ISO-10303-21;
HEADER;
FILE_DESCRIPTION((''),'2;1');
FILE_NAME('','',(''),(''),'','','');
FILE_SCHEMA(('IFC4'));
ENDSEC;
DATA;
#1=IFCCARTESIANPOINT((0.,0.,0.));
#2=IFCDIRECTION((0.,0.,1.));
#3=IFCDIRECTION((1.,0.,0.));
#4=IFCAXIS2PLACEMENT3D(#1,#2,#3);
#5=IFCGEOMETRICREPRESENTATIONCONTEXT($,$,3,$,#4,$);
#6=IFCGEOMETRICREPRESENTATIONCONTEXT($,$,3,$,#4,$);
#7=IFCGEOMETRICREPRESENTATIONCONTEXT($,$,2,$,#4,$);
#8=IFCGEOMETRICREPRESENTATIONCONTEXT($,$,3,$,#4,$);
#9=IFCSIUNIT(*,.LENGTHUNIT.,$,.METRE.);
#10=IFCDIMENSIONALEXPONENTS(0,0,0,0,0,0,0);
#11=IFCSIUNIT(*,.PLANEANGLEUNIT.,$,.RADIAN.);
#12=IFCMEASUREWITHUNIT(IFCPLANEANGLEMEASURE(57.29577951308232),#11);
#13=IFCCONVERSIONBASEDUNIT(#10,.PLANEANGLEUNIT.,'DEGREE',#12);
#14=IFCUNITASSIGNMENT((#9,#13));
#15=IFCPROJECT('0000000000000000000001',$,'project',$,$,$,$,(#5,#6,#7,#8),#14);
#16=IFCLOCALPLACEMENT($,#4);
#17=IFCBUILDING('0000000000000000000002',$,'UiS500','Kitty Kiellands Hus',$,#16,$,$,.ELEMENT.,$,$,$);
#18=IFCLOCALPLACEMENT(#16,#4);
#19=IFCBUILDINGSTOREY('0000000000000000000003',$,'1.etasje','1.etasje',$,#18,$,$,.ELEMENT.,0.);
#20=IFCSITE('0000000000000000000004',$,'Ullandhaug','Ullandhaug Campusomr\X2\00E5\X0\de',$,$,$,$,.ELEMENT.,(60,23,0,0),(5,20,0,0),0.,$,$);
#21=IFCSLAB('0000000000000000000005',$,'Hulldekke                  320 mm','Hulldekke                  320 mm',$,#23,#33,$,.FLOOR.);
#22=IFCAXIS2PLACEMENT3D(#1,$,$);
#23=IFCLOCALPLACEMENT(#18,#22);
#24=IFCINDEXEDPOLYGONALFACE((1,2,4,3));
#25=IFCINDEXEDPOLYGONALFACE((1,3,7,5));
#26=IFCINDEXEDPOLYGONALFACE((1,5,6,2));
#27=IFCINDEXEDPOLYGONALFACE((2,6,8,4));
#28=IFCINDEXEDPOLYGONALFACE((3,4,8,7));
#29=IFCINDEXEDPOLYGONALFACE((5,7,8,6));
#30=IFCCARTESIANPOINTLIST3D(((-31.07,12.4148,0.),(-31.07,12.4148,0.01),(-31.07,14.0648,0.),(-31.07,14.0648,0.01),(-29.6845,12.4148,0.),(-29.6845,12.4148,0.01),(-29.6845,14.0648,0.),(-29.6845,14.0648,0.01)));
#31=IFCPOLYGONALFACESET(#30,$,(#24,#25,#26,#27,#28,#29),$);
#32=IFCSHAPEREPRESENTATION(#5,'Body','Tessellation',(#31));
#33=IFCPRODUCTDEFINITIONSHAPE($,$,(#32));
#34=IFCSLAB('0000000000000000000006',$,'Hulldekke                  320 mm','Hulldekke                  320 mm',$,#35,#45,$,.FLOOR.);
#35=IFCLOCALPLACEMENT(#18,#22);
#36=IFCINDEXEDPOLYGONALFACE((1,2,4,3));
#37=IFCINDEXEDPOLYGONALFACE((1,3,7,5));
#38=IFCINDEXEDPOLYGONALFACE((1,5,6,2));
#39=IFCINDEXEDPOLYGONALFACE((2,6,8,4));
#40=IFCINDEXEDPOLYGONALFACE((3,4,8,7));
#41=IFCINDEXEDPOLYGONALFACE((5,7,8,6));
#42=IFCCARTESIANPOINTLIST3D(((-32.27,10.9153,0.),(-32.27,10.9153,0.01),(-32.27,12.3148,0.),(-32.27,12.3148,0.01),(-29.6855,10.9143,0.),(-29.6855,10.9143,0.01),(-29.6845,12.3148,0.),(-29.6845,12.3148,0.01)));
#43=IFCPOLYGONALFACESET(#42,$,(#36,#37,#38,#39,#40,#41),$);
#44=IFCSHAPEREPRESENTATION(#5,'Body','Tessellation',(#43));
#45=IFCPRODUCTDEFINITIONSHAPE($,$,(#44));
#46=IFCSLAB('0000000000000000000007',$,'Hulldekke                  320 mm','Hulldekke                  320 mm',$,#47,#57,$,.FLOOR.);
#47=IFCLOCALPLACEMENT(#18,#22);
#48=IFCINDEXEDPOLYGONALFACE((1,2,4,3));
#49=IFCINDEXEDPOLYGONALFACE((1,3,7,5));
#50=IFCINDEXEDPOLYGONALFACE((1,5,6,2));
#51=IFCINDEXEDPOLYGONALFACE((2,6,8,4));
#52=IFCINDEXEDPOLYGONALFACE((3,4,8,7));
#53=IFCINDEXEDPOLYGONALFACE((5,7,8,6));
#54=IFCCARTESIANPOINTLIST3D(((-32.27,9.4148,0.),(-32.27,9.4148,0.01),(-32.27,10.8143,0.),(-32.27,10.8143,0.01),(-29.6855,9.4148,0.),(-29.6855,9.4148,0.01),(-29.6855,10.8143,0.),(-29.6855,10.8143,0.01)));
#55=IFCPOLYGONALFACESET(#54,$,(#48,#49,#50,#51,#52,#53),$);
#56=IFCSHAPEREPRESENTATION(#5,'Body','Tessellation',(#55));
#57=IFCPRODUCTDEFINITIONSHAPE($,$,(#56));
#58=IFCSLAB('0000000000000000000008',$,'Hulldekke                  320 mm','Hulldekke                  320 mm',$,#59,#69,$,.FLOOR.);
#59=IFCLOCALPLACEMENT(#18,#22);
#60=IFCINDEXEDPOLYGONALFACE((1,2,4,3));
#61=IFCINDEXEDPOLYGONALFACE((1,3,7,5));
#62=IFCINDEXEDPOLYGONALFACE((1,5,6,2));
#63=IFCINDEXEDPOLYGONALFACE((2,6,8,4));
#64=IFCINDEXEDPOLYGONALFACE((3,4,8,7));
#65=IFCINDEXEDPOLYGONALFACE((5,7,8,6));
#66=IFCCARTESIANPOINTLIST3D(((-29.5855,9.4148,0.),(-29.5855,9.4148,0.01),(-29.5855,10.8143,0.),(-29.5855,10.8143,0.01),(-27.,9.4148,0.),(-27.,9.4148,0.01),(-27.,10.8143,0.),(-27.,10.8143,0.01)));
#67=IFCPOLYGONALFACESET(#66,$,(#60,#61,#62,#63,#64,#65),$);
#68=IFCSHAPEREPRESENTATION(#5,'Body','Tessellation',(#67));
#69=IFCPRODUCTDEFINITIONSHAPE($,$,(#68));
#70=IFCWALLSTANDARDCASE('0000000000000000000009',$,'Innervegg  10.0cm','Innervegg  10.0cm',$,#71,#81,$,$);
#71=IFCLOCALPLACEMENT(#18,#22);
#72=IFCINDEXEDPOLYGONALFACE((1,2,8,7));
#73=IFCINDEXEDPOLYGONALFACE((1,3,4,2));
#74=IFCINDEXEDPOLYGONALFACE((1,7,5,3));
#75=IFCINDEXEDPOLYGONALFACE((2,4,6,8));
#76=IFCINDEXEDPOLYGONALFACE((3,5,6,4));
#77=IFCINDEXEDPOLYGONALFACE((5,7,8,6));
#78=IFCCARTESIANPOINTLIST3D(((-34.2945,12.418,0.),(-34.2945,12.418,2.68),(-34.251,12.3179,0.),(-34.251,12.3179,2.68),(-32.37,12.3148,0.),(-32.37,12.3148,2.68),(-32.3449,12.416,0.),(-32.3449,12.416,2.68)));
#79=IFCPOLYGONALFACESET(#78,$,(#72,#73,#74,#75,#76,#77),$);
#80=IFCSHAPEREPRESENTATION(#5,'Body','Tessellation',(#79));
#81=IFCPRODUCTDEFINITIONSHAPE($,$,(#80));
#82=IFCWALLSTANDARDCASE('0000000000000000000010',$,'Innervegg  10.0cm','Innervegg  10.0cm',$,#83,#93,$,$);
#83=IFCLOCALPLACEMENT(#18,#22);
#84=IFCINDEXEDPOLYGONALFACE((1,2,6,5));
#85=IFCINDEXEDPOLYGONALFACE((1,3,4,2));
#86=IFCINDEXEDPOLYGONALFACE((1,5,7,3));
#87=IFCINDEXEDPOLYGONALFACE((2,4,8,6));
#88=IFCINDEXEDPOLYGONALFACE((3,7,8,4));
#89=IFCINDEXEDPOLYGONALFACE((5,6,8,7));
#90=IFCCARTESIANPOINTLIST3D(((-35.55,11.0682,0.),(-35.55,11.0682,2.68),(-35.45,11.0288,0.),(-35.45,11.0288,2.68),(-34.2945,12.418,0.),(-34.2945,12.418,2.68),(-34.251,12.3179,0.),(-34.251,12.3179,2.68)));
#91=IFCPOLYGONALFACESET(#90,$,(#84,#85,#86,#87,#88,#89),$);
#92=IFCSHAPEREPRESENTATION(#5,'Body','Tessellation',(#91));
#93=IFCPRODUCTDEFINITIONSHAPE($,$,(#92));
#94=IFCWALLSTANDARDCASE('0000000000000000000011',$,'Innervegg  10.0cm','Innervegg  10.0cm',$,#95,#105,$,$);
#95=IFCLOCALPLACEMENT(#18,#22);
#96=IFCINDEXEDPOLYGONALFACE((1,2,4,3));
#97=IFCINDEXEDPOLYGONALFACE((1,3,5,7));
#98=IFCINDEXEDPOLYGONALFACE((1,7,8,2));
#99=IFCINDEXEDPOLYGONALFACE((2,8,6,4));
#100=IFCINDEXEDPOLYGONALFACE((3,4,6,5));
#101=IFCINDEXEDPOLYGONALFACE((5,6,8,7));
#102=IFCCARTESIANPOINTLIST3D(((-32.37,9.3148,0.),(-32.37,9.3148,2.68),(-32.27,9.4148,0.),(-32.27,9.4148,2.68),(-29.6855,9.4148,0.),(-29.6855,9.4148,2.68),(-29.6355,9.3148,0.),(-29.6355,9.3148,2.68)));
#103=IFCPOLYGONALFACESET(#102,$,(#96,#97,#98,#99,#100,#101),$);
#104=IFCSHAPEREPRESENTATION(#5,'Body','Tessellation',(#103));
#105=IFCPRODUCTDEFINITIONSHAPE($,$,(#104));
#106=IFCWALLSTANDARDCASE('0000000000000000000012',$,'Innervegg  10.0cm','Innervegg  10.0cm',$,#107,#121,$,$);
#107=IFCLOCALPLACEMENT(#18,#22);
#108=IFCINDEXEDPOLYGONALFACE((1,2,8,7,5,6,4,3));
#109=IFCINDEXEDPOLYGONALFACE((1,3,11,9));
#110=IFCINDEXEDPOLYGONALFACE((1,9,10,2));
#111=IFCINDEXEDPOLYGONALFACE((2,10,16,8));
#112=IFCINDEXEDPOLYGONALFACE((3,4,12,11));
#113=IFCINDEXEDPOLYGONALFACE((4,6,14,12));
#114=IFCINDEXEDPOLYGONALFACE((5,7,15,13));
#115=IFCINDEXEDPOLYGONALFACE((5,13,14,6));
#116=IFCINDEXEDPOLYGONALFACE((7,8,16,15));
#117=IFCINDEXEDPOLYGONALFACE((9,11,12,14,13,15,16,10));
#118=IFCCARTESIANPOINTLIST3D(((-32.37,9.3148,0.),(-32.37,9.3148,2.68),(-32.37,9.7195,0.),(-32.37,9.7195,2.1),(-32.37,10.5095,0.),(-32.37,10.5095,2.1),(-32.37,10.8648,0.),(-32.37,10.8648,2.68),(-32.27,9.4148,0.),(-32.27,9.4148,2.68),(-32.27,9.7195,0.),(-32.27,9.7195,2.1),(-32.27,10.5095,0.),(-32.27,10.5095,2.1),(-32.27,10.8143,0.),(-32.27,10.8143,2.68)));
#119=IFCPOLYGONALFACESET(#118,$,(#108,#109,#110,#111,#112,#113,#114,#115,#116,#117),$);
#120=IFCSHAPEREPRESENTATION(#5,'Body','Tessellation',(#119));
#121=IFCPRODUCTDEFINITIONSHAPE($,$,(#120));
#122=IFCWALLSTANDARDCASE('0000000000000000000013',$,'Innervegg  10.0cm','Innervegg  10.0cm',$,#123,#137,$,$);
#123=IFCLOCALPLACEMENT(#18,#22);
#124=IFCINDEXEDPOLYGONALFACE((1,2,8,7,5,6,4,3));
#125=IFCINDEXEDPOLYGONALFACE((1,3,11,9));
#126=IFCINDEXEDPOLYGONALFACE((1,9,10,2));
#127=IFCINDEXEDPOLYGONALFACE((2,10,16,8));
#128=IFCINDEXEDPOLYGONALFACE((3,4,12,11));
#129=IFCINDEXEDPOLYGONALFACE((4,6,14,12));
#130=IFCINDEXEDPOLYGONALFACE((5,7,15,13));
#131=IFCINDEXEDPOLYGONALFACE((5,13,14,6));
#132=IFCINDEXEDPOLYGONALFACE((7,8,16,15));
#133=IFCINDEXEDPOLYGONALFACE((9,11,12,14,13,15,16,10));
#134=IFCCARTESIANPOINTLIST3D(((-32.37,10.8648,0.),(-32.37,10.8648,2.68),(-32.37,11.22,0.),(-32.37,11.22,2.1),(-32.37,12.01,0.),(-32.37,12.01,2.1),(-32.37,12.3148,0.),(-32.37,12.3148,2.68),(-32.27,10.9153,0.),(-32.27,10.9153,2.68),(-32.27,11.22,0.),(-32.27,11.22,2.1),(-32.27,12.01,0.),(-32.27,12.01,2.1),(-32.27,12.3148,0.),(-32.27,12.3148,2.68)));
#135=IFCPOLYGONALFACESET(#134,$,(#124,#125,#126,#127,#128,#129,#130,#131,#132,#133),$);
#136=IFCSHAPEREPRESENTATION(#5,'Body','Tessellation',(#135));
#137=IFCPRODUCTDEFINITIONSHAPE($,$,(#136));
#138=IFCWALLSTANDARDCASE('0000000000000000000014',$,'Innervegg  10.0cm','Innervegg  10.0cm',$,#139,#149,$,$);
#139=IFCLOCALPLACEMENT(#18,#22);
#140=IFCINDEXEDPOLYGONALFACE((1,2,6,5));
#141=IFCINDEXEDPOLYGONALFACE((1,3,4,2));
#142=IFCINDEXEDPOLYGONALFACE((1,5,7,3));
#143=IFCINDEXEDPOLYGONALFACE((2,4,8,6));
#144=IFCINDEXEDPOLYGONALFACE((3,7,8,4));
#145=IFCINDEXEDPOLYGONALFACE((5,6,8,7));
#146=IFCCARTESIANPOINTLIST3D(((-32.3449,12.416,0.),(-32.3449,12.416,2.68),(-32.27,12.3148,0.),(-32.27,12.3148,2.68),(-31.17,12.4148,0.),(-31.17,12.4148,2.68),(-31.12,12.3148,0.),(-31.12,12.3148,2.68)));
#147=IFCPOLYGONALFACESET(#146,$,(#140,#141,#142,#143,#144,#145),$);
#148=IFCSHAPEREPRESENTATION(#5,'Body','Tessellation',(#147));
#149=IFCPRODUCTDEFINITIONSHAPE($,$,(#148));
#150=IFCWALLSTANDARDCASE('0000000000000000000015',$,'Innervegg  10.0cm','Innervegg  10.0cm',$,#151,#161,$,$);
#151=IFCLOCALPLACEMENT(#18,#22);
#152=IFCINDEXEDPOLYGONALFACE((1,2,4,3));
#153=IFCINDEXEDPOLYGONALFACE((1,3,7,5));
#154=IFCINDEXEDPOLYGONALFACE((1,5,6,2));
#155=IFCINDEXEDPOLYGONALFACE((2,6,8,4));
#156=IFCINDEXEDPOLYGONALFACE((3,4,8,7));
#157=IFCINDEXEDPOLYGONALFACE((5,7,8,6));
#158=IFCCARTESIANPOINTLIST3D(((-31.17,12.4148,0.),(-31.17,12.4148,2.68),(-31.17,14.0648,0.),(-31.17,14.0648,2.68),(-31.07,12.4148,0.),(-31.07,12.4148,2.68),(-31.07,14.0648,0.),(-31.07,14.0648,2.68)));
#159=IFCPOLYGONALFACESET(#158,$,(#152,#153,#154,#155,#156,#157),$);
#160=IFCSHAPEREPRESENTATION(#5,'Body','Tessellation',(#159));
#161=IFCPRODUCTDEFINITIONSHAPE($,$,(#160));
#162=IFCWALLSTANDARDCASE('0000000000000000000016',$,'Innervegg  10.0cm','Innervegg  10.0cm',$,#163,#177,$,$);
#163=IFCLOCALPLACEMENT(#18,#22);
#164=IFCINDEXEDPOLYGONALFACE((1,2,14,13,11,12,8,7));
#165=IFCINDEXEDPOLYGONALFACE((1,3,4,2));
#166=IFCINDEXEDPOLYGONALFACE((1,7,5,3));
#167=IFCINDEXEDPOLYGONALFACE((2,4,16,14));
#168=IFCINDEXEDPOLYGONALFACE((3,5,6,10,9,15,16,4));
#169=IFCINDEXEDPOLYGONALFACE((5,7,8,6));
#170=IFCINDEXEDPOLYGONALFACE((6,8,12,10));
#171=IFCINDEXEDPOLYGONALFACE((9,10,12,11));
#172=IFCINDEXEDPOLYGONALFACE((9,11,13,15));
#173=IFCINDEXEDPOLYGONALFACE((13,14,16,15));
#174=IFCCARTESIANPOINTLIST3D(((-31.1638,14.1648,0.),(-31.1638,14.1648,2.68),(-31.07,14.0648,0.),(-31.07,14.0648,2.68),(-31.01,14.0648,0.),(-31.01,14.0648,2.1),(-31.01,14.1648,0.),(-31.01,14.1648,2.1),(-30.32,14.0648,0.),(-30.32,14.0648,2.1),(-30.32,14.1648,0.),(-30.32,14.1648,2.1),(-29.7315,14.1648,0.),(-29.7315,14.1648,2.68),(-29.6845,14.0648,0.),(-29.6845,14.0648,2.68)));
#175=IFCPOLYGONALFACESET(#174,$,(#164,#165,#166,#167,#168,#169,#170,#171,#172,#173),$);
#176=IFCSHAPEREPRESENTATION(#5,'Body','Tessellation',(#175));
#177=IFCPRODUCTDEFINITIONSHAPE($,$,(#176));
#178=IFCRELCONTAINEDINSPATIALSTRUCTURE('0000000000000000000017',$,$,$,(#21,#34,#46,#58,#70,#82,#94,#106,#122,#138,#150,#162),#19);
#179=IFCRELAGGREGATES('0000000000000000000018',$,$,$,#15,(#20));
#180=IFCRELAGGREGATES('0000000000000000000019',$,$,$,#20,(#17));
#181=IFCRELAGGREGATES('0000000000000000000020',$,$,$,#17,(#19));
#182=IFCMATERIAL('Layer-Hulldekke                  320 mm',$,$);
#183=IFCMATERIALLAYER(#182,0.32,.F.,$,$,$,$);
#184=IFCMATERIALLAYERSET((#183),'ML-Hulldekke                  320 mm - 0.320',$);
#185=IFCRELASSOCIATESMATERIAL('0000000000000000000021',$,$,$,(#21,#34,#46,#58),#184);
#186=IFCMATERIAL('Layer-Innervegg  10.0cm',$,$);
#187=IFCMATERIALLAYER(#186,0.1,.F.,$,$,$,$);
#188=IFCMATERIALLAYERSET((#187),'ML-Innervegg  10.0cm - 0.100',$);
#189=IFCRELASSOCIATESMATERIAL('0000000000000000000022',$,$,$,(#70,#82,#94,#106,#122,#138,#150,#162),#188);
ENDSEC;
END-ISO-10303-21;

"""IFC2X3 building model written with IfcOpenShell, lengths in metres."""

from ifc_helpers import new_model, entity, si_unit, converted_unit, frame, origin_with_axes, place, context, project, spatial, polyline, outline, extrude, material, layer, layer_set, layer_usage, element, save


model = new_model("IFC2X3")

# Units and contexts
context_of_model_1 = context(None, 3, world=origin_with_axes())
context_of_model_2 = context(None, 3, world=origin_with_axes())
context_of_model_3 = context(None, 2, world=origin_with_axes())
context_of_model_4 = context(None, 3, world=origin_with_axes())
ifc_project = project(units=[si_unit("LENGTHUNIT", "METRE"), converted_unit("PLANEANGLEUNIT", "DEGREE", entity("IfcPlaneAngleMeasure", 57.29577951308232), si_unit("PLANEANGLEUNIT", "RADIAN"), dimensions=[0, 0, 0, 0, 0, 0, 0])], contexts=[context_of_model_1, context_of_model_2, context_of_model_3, context_of_model_4])

# Site, building, storey
site = spatial("IfcSite", under=ifc_project, Name="Ullandhaug", Description="Ullandhaug Campusområde", CompositionType="ELEMENT", RefLatitude=(60, 23, 0, 0), RefLongitude=(5, 20, 0, 0), RefElevation=0.0)
building_placement = place(None, origin_with_axes())
building = spatial("IfcBuilding", under=site, at=building_placement, Name="UiS500", Description="Kitty Kiellands Hus", CompositionType="ELEMENT")
storey_placement = place(building_placement, origin_with_axes())
storey = spatial("IfcBuildingStorey", under=building, at=storey_placement, Name="1.etasje", Description="1.etasje", CompositionType="ELEMENT", Elevation=0.0)

# Slabs
ifc_material_1 = material(Name="Layer-Hulldekke                  320 mm")
ifc_layer_1 = layer(ifc_material_1, 0.32, ventilated=False)
ifc_layer_set_1 = layer_set([ifc_layer_1], Name="ML-Hulldekke                  320 mm - 0.320")
ifc_layer_usage_1 = layer_usage(ifc_layer_set_1, "AXIS2", "POSITIVE", 0.0)
slab_1_placement = place(storey_placement, frame((-31.07, 14.0648, 0.0), z_axis=(0.0, 0.0, 1.0), x_axis=(1.0, 0.0, 0.0)))
element("IfcSlab", 1, at=slab_1_placement, inside=storey, material=ifc_layer_usage_1, Name="Hulldekke                  320 mm", Description="Hulldekke                  320 mm", PredefinedType="FLOOR", context=context_of_model_1, shape_type="SweptSolid", body=[
    extrude(outline(polyline([(0.0, 0.0), (1.65, 0.0), (1.65, 1.3855), (0.0, 1.3855), (0.0, 0.0)])), frame((0.0, 0.0, 0.0), z_axis=(0.0, 0.0, 1.0), x_axis=(0.0, -1.0, 0.0)), (0.0, 0.0, 1.0), 0.01),
])
slab_2_placement = place(storey_placement, frame((-29.6855, 10.9143, 0.0), z_axis=(0.0, 0.0, 1.0), x_axis=(1.0, 0.0, 0.0)))
element("IfcSlab", 2, at=slab_2_placement, inside=storey, material=ifc_layer_usage_1, Name="Hulldekke                  320 mm", Description="Hulldekke                  320 mm", PredefinedType="FLOOR", context=context_of_model_1, shape_type="SweptSolid", body=[
    extrude(outline(polyline([(0.0, 0.0), (1.4005, 0.0), (1.3987, 2.5855), (-0.0008, 2.5845), (0.0, 0.0)])), frame((0.0, 0.0, 0.0), z_axis=(0.0, 0.0, 1.0), x_axis=(0.000712, 1.0, 0.0)), (0.0, 0.0, 1.0), 0.01),
])
slab_3_placement = place(storey_placement, frame((-29.6855, 10.8143, 0.0), z_axis=(0.0, 0.0, 1.0), x_axis=(1.0, 0.0, 0.0)))
element("IfcSlab", 3, at=slab_3_placement, inside=storey, material=ifc_layer_usage_1, Name="Hulldekke                  320 mm", Description="Hulldekke                  320 mm", PredefinedType="FLOOR", context=context_of_model_1, shape_type="SweptSolid", body=[
    extrude(outline(polyline([(0.0, 0.0), (2.5845, 0.0), (2.5845, 1.3995), (0.0, 1.3995), (0.0, 0.0)])), frame((0.0, 0.0, 0.0), z_axis=(0.0, 0.0, 1.0), x_axis=(-1.0, 0.0, 0.0)), (0.0, 0.0, 1.0), 0.01),
])
slab_4_placement = place(storey_placement, frame((-29.5855, 10.8143, 0.0), z_axis=(0.0, 0.0, 1.0), x_axis=(1.0, 0.0, 0.0)))
element("IfcSlab", 4, at=slab_4_placement, inside=storey, material=ifc_layer_usage_1, Name="Hulldekke                  320 mm", Description="Hulldekke                  320 mm", PredefinedType="FLOOR", context=context_of_model_1, shape_type="SweptSolid", body=[
    extrude(outline(polyline([(0.0, 0.0), (1.3995, 0.0), (1.3995, 2.5855), (0.0, 2.5855), (0.0, 0.0)])), frame((0.0, 0.0, 0.0), z_axis=(0.0, 0.0, 1.0), x_axis=(0.0, -1.0, 0.0)), (0.0, 0.0, 1.0), 0.01),
])

# Walls
ifc_material_2 = material(Name="Layer-Innervegg  10.0cm")
ifc_layer_2 = layer(ifc_material_2, 0.1, ventilated=False)
ifc_layer_set_2 = layer_set([ifc_layer_2], Name="ML-Innervegg  10.0cm - 0.100")
ifc_layer_usage_2 = layer_usage(ifc_layer_set_2, "AXIS2", "POSITIVE", 0.0)
wall_1_placement = place(storey_placement, frame((-32.3449, 12.416, 0.0), z_axis=(0.0, 0.0, 1.0), x_axis=(-0.999999, 0.001033, 0.0)))
element("IfcWallStandardCase", 5, at=wall_1_placement, inside=storey, material=ifc_layer_usage_2, Name="Innervegg  10.0cm", Description="Innervegg  10.0cm", context=context_of_model_1, shape_type="SweptSolid", body=[
    extrude(outline(polyline([(0.0, 0.0), (1.9496, 0.0), (1.906, 0.1), (0.025, 0.1012), (0.0, 0.0)])), frame((0.0, 0.0, 0.0), z_axis=(0.0, 0.0, 1.0), x_axis=(1.0, 0.0, 0.0)), (0.0, 0.0, 1.0), 2.68),
])
wall_2_placement = place(storey_placement, frame((-34.2945, 12.418, 0.0), z_axis=(0.0, 0.0, 1.0), x_axis=(-0.681068, -0.73222, 0.0)))
element("IfcWallStandardCase", 6, at=wall_2_placement, inside=storey, material=ifc_layer_usage_2, Name="Innervegg  10.0cm", Description="Innervegg  10.0cm", context=context_of_model_1, shape_type="SweptSolid", body=[
    extrude(outline(polyline([(0.0, 0.0), (1.8435, 0.0), (1.8041, 0.1), (0.0436, 0.1), (0.0, 0.0)])), frame((0.0, 0.0, 0.0), z_axis=(0.0, 0.0, 1.0), x_axis=(1.0, 0.0, 0.0)), (0.0, 0.0, 1.0), 2.68),
])
wall_3_placement = place(storey_placement, frame((-29.6855, 9.4148, 0.0), z_axis=(0.0, 0.0, 1.0), x_axis=(-1.0, 0.0, 0.0)))
element("IfcWallStandardCase", 7, at=wall_3_placement, inside=storey, material=ifc_layer_usage_2, Name="Innervegg  10.0cm", Description="Innervegg  10.0cm", context=context_of_model_1, shape_type="SweptSolid", body=[
    extrude(outline(polyline([(0.0, 0.0), (2.5845, 0.0), (2.6845, 0.1), (-0.05, 0.1), (0.0, 0.0)])), frame((0.0, 0.0, 0.0), z_axis=(0.0, 0.0, 1.0), x_axis=(1.0, 0.0, 0.0)), (0.0, 0.0, 1.0), 2.68),
])

# Walls, openings
wall_4_placement = place(storey_placement, frame((-32.27, 9.4148, 0.0), z_axis=(0.0, 0.0, 1.0), x_axis=(0.0, 1.0, 0.0)))
wall_4 = element("IfcWallStandardCase", 8, at=wall_4_placement, inside=storey, material=ifc_layer_usage_2, Name="Innervegg  10.0cm", Description="Innervegg  10.0cm", context=context_of_model_1, shape_type="SweptSolid", body=[
    extrude(outline(polyline([(0.0, 0.0), (1.3995, 0.0), (1.45, 0.1), (-0.1, 0.1), (0.0, 0.0)])), frame((0.0, 0.0, 0.0), z_axis=(0.0, 0.0, 1.0), x_axis=(1.0, 0.0, 0.0)), (0.0, 0.0, 1.0), 2.68),
])
opening_1_placement = place(wall_4_placement, frame((0.3048, 0.1, 0.0), z_axis=(0.0, 0.0, 1.0), x_axis=(1.0, 0.0, 0.0)))
element("IfcOpeningElement", 9, at=opening_1_placement, cuts=wall_4, context=context_of_model_1, shape_type="SweptSolid", body=[
    extrude(outline(polyline([(0.0, 0.0), (2.1, 0.0), (2.1, 0.79), (0.0, 0.79), (0.0, 0.0)])), frame((0.0, 0.0, 0.0), z_axis=(0.0, 1.0, 0.0), x_axis=(0.0, 0.0, 1.0)), (0.0, 0.0, -1.0), 0.1),
])
wall_5_placement = place(storey_placement, frame((-32.27, 10.9153, 0.0), z_axis=(0.0, 0.0, 1.0), x_axis=(0.0, 1.0, 0.0)))
wall_5 = element("IfcWallStandardCase", 10, at=wall_5_placement, inside=storey, material=ifc_layer_usage_2, Name="Innervegg  10.0cm", Description="Innervegg  10.0cm", context=context_of_model_1, shape_type="SweptSolid", body=[
    extrude(outline(polyline([(0.0, 0.0), (1.3995, 0.0), (1.3995, 0.1), (-0.0505, 0.1), (0.0, 0.0)])), frame((0.0, 0.0, 0.0), z_axis=(0.0, 0.0, 1.0), x_axis=(1.0, 0.0, 0.0)), (0.0, 0.0, 1.0), 2.68),
])
opening_2_placement = place(wall_5_placement, frame((0.3048, 0.1, 0.0), z_axis=(0.0, 0.0, 1.0), x_axis=(1.0, 0.0, 0.0)))
element("IfcOpeningElement", 11, at=opening_2_placement, cuts=wall_5, context=context_of_model_1, shape_type="SweptSolid", body=[
    extrude(outline(polyline([(0.0, 0.0), (2.1, 0.0), (2.1, 0.79), (0.0, 0.79), (0.0, 0.0)])), frame((0.0, 0.0, 0.0), z_axis=(0.0, 1.0, 0.0), x_axis=(0.0, 0.0, 1.0)), (0.0, 0.0, -1.0), 0.1),
])

# Walls
wall_6_placement = place(storey_placement, frame((-32.27, 12.3148, 0.0), z_axis=(0.0, 0.0, 1.0), x_axis=(1.0, 0.0, 0.0)))
element("IfcWallStandardCase", 12, at=wall_6_placement, inside=storey, material=ifc_layer_usage_2, Name="Innervegg  10.0cm", Description="Innervegg  10.0cm", context=context_of_model_1, shape_type="SweptSolid", body=[
    extrude(outline(polyline([(0.0, 0.0), (1.15, 0.0), (1.1, 0.1), (-0.0749, 0.1012), (0.0, 0.0)])), origin_with_axes(), (0.0, 0.0, 1.0), 2.68),
])
wall_7_placement = place(storey_placement, frame((-31.07, 12.4148, 0.0), z_axis=(0.0, 0.0, 1.0), x_axis=(0.0, 1.0, 0.0)))
element("IfcWallStandardCase", 13, at=wall_7_placement, inside=storey, material=ifc_layer_usage_2, Name="Innervegg  10.0cm", Description="Innervegg  10.0cm", context=context_of_model_1, shape_type="SweptSolid", body=[
    extrude(outline(polyline([(0.0, 0.0), (1.65, 0.0), (1.65, 0.1), (0.0, 0.1), (0.0, 0.0)])), frame((0.0, 0.0, 0.0), z_axis=(0.0, 0.0, 1.0), x_axis=(1.0, 0.0, 0.0)), (0.0, 0.0, 1.0), 2.68),
])

# Wall, opening
wall_8_placement = place(storey_placement, frame((-31.07, 14.0648, 0.0), z_axis=(0.0, 0.0, 1.0), x_axis=(1.0, 0.0, 0.0)))
wall_8 = element("IfcWallStandardCase", 14, at=wall_8_placement, inside=storey, material=ifc_layer_usage_2, Name="Innervegg  10.0cm", Description="Innervegg  10.0cm", context=context_of_model_1, shape_type="SweptSolid", body=[
    extrude(outline(polyline([(0.0, 0.0), (1.3855, 0.0), (1.3385, 0.1), (-0.0938, 0.1), (0.0, 0.0)])), origin_with_axes(), (0.0, 0.0, 1.0), 2.68),
])
opening_3_placement = place(wall_8_placement, frame((0.06, 0.1, 0.0), z_axis=(0.0, 0.0, 1.0), x_axis=(1.0, 0.0, 0.0)))
element("IfcOpeningElement", 15, at=opening_3_placement, cuts=wall_8, context=context_of_model_1, shape_type="SweptSolid", body=[
    extrude(outline(polyline([(0.0, 0.0), (2.1, 0.0), (2.1, 0.69), (0.0, 0.69), (0.0, 0.0)])), frame((0.0, 0.0, 0.0), z_axis=(0.0, 1.0, 0.0), x_axis=(0.0, 0.0, 1.0)), (0.0, 0.0, -1.0), 0.1),
])

save(model, "model.ifc")
